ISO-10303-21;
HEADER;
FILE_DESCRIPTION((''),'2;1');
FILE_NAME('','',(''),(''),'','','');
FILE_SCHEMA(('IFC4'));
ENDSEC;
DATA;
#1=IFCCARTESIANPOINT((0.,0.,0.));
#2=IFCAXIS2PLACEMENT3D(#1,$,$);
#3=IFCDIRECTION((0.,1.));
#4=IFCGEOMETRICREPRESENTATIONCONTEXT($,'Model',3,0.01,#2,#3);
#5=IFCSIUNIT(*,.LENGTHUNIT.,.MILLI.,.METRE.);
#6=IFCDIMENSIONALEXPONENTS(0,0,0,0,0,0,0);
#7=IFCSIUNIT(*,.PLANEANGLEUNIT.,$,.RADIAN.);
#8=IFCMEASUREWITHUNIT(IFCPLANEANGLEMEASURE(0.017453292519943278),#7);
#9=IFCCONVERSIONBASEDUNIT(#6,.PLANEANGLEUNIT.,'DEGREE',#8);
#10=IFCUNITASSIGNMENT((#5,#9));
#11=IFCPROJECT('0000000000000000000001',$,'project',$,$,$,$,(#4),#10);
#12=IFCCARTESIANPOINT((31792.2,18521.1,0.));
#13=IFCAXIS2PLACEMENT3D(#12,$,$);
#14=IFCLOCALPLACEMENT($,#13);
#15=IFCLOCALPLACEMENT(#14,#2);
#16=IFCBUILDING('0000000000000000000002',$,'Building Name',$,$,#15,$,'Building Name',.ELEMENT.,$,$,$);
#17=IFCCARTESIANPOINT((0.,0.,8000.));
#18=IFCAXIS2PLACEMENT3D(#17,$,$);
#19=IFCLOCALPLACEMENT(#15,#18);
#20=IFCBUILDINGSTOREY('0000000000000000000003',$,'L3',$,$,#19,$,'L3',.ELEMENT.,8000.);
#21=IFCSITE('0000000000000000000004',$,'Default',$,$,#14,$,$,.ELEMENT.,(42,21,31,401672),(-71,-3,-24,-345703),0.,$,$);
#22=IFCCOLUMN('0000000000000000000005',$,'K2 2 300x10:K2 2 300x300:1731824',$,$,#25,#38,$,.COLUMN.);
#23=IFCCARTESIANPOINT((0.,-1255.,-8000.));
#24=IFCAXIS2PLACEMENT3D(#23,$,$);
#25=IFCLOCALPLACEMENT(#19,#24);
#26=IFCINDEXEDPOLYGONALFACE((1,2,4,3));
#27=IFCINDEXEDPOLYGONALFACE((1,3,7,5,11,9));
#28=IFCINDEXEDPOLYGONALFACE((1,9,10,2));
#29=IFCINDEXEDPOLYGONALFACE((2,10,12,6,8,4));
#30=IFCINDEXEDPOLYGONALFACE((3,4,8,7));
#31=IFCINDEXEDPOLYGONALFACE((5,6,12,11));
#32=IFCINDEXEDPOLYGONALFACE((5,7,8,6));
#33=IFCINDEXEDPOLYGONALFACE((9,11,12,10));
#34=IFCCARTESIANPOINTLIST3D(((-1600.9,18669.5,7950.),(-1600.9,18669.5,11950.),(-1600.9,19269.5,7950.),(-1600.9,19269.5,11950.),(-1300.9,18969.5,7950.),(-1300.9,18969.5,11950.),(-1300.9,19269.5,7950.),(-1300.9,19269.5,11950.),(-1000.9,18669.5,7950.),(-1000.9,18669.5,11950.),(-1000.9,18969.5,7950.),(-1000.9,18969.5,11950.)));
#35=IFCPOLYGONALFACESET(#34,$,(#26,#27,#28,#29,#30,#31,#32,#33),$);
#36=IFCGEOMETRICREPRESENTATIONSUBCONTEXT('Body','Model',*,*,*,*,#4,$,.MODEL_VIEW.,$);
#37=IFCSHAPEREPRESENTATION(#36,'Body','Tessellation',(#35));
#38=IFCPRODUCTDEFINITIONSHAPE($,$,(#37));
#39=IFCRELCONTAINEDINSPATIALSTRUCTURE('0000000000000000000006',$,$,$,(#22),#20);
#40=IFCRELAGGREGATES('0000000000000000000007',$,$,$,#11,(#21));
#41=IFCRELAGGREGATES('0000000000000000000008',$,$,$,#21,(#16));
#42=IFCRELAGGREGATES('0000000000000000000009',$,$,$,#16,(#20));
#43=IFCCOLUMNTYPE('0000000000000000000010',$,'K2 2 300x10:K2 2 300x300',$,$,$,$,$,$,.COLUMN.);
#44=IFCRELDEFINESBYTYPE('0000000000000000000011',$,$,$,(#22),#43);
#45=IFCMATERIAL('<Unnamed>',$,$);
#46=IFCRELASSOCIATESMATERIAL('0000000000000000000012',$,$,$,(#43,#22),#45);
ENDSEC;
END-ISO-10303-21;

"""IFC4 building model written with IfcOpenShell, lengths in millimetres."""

from ifc_helpers import new_model, entity, si_unit, converted_unit, direction, frame, origin, place, context, subcontext, project, spatial, indexed_curve, outline, extrude, source, transform, mapped, material, type_object, type_shapes, element, save


model = new_model("IFC4")

# Units and contexts
model_context = context("Model", 3, precision=0.01, world=origin(), true_north=direction((0.0, 1.0)))
body_context = subcontext(model_context, "Body", "Model", "MODEL_VIEW")
ifc_project = project(units=[si_unit("LENGTHUNIT", "METRE", prefix="MILLI"), converted_unit("PLANEANGLEUNIT", "DEGREE", entity("IfcPlaneAngleMeasure", 0.017453292519943278), si_unit("PLANEANGLEUNIT", "RADIAN"), dimensions=[0, 0, 0, 0, 0, 0, 0])], contexts=[model_context])

# Site, building, storey
site_placement = place(None, frame((31792.2, 18521.1, 0.0)))
site = spatial("IfcSite", under=ifc_project, at=site_placement, Name="Default", CompositionType="ELEMENT", RefLatitude=(42, 21, 31, 401672), RefLongitude=(-71, -3, -24, -345703), RefElevation=0.0)
building_placement = place(site_placement, origin())
building = spatial("IfcBuilding", under=site, at=building_placement, Name="Building Name", LongName="Building Name", CompositionType="ELEMENT")
storey_placement = place(building_placement, frame((0.0, 0.0, 8000.0)))
storey = spatial("IfcBuildingStorey", under=building, at=storey_placement, Name="L3", LongName="L3", CompositionType="ELEMENT", Elevation=8000.0)

# Column
ifc_material_1 = material(Name="<Unnamed>")
column_type_1 = type_object("IfcColumnType", Name="K2 2 300x10:K2 2 300x300", PredefinedType="COLUMN", material=ifc_material_1)
shared_shape_1 = source(origin(), body_context, "Body", "SweptSolid", [
    extrude(outline(indexed_curve([(-300.0, 0.0), (-300.0, -300.0), (300.0, -300.0), (300.0, 300.0), (0.0, 300.0), (0.0, 0.0), (-300.0, 0.0)], self_intersect=False)), frame((-1300.9, 18969.5, 7950.0), z_axis=(0.0, 0.0, -1.0), x_axis=(-1.0, 0.0, 0.0)), (0.0, 0.0, -1.0), 4000.0),
])
type_shapes(column_type_1, [shared_shape_1])
column_1_placement = place(storey_placement, frame((0.0, -1255.0, -8000.0)))
element("IfcColumn", 1, at=column_1_placement, inside=storey, type_object=column_type_1, material=ifc_material_1, Name="K2 2 300x10:K2 2 300x300:1731824", PredefinedType="COLUMN", context=body_context, shape_type="MappedRepresentation", body=[
    mapped(shared_shape_1, transform((0.0, 0.0, 0.0), scale=1.0)),
])

save(model, "model.ifc")
